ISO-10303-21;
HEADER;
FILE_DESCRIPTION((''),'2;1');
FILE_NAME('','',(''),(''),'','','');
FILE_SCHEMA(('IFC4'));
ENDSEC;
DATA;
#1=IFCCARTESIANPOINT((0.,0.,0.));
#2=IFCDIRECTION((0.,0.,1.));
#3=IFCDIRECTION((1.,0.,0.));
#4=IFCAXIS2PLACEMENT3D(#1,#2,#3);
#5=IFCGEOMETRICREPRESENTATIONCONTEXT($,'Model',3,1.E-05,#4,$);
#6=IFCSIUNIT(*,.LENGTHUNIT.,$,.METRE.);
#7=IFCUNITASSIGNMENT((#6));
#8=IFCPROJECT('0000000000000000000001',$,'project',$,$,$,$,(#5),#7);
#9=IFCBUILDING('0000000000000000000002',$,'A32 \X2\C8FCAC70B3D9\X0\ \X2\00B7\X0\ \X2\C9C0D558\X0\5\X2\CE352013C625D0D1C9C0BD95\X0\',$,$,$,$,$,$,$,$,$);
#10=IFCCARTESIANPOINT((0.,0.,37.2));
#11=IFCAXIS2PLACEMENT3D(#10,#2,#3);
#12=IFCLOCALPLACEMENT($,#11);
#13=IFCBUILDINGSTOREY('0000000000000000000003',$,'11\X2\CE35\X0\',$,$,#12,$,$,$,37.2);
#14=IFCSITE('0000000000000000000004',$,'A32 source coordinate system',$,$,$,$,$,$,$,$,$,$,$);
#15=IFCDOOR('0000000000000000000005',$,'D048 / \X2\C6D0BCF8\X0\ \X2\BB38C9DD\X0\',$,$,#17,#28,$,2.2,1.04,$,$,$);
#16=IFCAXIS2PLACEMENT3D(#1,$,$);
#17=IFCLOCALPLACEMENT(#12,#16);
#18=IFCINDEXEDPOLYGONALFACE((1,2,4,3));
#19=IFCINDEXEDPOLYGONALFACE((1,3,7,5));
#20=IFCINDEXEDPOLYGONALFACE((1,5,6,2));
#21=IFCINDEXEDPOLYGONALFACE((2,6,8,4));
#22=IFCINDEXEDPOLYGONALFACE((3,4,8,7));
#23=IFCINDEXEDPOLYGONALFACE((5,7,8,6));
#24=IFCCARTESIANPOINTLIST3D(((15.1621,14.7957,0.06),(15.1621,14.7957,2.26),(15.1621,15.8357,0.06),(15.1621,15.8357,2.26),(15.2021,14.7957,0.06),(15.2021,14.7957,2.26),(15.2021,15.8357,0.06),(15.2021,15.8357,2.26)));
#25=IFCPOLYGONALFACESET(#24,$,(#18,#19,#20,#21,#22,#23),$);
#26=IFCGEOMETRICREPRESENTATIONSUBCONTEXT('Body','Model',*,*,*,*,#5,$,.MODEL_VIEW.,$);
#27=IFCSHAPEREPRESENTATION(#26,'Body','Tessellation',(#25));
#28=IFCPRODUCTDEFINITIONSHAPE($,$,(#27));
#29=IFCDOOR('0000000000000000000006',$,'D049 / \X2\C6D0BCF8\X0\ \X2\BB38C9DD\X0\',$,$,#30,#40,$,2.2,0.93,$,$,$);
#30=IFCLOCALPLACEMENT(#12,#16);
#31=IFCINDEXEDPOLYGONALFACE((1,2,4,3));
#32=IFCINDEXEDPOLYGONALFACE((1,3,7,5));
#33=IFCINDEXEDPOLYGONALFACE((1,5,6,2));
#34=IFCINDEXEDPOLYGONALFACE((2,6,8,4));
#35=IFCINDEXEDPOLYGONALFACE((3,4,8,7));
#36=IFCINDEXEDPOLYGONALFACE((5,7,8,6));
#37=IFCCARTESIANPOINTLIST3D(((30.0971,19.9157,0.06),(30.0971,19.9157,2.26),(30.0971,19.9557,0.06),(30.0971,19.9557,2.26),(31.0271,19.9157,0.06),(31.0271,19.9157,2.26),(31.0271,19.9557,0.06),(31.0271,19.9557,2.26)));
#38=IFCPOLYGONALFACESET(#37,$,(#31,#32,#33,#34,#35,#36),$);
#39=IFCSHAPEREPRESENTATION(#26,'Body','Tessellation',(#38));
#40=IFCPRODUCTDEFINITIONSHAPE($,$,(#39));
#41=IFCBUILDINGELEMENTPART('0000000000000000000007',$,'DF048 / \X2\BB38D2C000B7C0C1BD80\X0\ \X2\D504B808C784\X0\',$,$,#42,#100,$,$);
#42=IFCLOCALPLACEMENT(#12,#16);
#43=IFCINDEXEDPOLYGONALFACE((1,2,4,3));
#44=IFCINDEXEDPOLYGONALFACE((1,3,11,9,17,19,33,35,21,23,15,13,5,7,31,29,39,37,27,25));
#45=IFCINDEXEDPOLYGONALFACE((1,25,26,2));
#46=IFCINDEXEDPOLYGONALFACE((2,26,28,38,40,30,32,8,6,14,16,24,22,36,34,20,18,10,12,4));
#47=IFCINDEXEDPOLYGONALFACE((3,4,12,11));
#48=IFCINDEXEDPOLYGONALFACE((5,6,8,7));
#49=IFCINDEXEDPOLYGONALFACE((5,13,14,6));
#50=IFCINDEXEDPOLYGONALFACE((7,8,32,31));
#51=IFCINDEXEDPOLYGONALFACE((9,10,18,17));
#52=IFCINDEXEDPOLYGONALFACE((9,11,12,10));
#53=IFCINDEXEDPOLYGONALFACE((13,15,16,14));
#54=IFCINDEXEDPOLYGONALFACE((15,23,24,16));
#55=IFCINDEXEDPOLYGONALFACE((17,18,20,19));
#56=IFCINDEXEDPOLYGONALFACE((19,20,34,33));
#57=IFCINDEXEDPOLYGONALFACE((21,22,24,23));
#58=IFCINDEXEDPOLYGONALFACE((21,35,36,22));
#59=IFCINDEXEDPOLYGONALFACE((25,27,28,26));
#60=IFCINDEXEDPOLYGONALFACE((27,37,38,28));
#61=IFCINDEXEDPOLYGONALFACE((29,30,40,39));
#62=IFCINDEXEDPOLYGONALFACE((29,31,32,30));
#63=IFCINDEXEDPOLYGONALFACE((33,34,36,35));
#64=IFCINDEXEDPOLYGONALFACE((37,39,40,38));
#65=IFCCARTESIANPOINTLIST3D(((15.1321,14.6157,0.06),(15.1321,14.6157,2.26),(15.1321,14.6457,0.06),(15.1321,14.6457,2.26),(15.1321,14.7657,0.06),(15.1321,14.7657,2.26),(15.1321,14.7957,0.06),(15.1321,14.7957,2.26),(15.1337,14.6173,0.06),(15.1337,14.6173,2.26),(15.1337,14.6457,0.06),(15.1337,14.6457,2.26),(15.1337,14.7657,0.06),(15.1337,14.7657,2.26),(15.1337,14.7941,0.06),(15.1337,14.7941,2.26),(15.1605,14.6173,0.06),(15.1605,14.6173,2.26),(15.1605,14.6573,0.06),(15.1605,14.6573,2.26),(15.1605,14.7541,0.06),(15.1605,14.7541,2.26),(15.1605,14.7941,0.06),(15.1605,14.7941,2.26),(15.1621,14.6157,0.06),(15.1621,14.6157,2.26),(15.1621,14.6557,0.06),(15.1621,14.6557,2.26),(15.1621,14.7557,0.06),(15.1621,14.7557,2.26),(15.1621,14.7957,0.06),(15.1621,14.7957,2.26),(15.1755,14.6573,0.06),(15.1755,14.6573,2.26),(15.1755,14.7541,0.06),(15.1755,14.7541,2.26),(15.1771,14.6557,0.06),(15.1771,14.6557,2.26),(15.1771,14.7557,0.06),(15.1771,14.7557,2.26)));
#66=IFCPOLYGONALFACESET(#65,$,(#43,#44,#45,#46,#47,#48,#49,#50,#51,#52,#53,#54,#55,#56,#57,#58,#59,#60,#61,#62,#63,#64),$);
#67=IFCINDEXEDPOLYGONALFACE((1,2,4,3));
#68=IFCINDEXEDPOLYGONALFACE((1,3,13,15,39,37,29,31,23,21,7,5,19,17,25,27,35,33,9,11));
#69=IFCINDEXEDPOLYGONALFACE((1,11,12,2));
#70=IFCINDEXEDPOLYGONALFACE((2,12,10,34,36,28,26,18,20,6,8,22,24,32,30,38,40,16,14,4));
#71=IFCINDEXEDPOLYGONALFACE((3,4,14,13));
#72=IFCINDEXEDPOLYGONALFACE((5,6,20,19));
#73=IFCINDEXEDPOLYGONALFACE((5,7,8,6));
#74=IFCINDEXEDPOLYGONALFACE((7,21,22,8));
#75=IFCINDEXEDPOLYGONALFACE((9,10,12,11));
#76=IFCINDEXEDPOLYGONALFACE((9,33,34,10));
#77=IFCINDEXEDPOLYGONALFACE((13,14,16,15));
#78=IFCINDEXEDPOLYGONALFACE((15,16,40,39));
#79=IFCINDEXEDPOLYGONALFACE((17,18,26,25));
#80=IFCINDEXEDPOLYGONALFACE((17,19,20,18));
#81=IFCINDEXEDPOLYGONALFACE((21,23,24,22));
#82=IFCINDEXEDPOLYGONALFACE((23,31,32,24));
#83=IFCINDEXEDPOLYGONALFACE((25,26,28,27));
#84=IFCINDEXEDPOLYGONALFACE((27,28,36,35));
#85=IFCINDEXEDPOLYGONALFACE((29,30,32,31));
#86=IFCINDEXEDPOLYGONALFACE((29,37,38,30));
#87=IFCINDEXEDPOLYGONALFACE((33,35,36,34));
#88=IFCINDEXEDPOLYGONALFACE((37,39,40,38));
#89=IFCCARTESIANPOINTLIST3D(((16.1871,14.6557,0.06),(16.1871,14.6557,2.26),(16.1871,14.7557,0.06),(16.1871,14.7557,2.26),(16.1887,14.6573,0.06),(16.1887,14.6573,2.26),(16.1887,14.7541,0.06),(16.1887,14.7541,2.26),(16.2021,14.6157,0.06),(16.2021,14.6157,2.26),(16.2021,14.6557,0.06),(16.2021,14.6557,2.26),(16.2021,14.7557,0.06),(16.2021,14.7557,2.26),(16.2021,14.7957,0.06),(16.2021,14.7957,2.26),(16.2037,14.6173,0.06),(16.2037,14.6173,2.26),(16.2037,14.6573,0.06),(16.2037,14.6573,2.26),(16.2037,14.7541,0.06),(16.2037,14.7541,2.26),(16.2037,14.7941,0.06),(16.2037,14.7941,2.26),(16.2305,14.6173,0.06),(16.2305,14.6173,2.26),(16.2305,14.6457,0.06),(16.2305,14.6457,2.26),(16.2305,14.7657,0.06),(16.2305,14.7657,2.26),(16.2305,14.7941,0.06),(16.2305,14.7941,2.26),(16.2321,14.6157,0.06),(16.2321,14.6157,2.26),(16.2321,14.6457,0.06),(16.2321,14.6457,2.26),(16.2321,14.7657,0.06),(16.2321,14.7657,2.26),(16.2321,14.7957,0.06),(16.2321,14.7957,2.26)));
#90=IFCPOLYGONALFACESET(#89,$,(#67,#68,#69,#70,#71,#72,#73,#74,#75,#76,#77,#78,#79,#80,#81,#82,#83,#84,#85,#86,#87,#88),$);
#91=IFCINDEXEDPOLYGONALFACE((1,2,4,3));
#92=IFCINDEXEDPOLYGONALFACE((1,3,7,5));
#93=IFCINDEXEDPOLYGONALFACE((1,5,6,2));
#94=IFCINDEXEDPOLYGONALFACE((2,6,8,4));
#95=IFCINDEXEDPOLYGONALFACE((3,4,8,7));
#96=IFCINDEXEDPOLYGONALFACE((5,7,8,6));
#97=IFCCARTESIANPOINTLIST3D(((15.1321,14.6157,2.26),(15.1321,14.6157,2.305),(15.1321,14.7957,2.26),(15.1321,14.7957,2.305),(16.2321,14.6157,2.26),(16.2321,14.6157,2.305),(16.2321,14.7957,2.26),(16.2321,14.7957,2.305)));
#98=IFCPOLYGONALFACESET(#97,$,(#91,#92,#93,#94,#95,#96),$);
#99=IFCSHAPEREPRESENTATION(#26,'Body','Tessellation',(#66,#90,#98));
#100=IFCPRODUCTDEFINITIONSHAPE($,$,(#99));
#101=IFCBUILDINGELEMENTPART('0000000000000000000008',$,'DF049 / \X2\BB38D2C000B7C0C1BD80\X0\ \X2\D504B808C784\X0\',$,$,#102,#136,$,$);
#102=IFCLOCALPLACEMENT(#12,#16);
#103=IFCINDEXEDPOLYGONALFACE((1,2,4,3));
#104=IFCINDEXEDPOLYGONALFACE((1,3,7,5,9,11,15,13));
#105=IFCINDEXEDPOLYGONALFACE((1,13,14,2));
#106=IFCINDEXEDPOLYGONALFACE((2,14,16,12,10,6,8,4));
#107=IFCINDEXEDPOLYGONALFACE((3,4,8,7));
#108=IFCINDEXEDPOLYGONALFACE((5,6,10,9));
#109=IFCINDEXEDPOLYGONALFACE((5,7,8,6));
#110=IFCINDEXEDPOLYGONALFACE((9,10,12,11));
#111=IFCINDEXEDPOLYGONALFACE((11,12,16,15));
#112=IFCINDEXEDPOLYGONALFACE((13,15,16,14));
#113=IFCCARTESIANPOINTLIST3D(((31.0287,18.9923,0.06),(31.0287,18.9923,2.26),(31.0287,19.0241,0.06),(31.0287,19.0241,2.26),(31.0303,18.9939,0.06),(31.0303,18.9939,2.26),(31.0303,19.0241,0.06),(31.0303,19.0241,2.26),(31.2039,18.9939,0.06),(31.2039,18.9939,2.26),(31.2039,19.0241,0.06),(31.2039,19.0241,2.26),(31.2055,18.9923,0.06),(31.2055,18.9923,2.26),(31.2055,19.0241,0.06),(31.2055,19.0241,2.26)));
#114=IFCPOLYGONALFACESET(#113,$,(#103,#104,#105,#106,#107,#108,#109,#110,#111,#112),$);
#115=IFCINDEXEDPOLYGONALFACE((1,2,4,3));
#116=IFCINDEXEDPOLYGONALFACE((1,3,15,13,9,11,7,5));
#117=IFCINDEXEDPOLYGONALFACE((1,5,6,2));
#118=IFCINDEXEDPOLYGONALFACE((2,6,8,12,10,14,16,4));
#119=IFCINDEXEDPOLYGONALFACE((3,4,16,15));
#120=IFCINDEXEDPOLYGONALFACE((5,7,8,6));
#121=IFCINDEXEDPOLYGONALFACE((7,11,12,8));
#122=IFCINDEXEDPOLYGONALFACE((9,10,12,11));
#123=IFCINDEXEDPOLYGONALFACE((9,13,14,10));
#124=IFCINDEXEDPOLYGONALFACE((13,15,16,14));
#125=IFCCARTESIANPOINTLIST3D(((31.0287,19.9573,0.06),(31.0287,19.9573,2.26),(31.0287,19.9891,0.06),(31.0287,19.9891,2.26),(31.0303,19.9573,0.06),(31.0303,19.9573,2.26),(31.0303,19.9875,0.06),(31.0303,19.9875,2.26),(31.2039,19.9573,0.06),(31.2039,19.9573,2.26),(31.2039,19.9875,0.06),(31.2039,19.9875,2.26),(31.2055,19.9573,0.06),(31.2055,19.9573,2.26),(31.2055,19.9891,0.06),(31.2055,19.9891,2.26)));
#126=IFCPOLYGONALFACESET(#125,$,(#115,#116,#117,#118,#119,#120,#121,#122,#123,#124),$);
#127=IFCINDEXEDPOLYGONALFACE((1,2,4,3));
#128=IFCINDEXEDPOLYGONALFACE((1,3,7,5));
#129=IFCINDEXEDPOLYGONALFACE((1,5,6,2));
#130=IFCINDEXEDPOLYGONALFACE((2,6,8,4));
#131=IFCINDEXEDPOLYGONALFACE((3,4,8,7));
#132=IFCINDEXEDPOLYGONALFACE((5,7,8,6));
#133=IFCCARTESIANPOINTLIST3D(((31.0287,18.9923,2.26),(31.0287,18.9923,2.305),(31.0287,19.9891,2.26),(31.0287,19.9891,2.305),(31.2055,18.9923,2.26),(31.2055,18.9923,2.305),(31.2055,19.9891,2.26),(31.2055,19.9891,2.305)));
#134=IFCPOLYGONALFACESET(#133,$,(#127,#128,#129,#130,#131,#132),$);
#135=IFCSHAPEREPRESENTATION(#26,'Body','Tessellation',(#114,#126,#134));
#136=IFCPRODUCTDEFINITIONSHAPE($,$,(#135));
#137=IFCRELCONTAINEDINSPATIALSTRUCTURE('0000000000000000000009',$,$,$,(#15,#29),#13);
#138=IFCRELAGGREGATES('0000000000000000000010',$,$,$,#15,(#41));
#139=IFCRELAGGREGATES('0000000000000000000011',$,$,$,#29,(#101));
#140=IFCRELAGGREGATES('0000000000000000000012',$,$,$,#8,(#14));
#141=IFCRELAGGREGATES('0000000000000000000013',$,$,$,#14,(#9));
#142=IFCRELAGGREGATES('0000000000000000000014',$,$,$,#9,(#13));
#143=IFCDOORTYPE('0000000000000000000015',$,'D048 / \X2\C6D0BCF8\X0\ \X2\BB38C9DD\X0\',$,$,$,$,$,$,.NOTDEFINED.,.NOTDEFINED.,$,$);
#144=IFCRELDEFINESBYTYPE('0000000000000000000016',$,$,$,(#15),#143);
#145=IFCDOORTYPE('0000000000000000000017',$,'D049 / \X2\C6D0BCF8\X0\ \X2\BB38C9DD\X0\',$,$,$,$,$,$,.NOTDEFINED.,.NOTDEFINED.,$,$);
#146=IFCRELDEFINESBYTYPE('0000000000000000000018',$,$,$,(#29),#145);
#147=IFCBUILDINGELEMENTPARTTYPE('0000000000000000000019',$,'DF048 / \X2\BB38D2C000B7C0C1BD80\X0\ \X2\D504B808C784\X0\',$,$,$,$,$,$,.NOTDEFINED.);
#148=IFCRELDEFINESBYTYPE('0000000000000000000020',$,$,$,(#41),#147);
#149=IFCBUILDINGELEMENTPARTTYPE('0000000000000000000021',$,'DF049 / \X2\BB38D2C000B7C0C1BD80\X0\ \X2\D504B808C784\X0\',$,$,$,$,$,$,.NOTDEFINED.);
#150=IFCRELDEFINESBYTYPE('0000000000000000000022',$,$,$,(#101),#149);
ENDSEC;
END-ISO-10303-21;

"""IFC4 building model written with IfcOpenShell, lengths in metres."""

from ifc_helpers import new_model, si_unit, frame, origin, origin_with_axes, place, context, subcontext, project, spatial, polyline, outline, extrude, source, transform, mapped, type_object, type_shapes, element, aggregate, save


model = new_model("IFC4")

# Units and contexts
model_context = context("Model", 3, precision=1e-05, world=origin_with_axes())
body_context = subcontext(model_context, "Body", "Model", "MODEL_VIEW")
ifc_project = project(units=[si_unit("LENGTHUNIT", "METRE")], contexts=[model_context])

# Site, building, storey
storey_placement = place(None, frame((0.0, 0.0, 37.2), z_axis=(0.0, 0.0, 1.0), x_axis=(1.0, 0.0, 0.0)))
site = spatial("IfcSite", under=ifc_project, Name="A32 source coordinate system")
building = spatial("IfcBuilding", under=site, Name="A32 주거동 · 지하5층–옥탑지붕")
storey = spatial("IfcBuildingStorey", under=building, at=storey_placement, Name="11층", Elevation=37.2)

# Doors
door_type_1 = type_object("IfcDoorType", Name="D048 / 원본 문짝", OperationType="NOTDEFINED", PredefinedType="NOTDEFINED")
shared_shape_1 = source(origin(), body_context, "Body", "SweptSolid", [
    extrude(outline(polyline([(15.2021, 15.8357), (15.2021, 14.7957), (15.1621, 14.7957), (15.1621, 15.8357), (15.2021, 15.8357)])), frame((0.0, 0.0, 0.06)), (0.0, 0.0, 1.0), 2.2),
])
type_shapes(door_type_1, [shared_shape_1])
door_1_placement = place(storey_placement, origin_with_axes())
door_1 = element("IfcDoor", 1, at=door_1_placement, inside=storey, type_object=door_type_1, Name="D048 / 원본 문짝", OverallHeight=2.2, OverallWidth=1.04, context=body_context, shape_type="MappedRepresentation", body=[
    mapped(shared_shape_1, transform((0.0, 0.0, 0.0), scale=1.0)),
])
door_type_2 = type_object("IfcDoorType", Name="D049 / 원본 문짝", OperationType="NOTDEFINED", PredefinedType="NOTDEFINED")
shared_shape_2 = source(origin(), body_context, "Body", "SweptSolid", [
    extrude(outline(polyline([(31.0271, 19.9557), (31.0271, 19.9157), (30.0971, 19.9157), (30.0971, 19.9557), (31.0271, 19.9557)])), frame((0.0, 0.0, 0.06)), (0.0, 0.0, 1.0), 2.2),
])
type_shapes(door_type_2, [shared_shape_2])
door_2_placement = place(storey_placement, origin_with_axes())
door_2 = element("IfcDoor", 2, at=door_2_placement, inside=storey, type_object=door_type_2, Name="D049 / 원본 문짝", OverallHeight=2.2, OverallWidth=0.93, context=body_context, shape_type="MappedRepresentation", body=[
    mapped(shared_shape_2, transform((0.0, 0.0, 0.0), scale=1.0)),
])

# Building element parts
building_element_part_type_1 = type_object("IfcBuildingElementPartType", Name="DF048 / 문틀·상부 프레임", PredefinedType="NOTDEFINED")
shared_shape_3 = source(origin(), body_context, "Body", "SweptSolid", [
    extrude(outline(polyline([(15.1321, 14.7657), (15.1321, 14.7957), (15.1621, 14.7957), (15.1621, 14.7557), (15.1771, 14.7557), (15.1771, 14.6557), (15.1621, 14.6557), (15.1621, 14.6157), (15.1321, 14.6157), (15.1321, 14.6457), (15.1337, 14.6457), (15.1337, 14.6173), (15.1605, 14.6173), (15.1605, 14.6573), (15.1755, 14.6573), (15.1755, 14.7541), (15.1605, 14.7541), (15.1605, 14.7941), (15.1337, 14.7941), (15.1337, 14.7657), (15.1321, 14.7657)])), frame((0.0, 0.0, 0.06)), (0.0, 0.0, 1.0), 2.2),
    extrude(outline(polyline([(16.2305, 14.7941), (16.2037, 14.7941), (16.2037, 14.7541), (16.1887, 14.7541), (16.1887, 14.6573), (16.2037, 14.6573), (16.2037, 14.6173), (16.2305, 14.6173), (16.2305, 14.6457), (16.2321, 14.6457), (16.2321, 14.6157), (16.2021, 14.6157), (16.2021, 14.6557), (16.1871, 14.6557), (16.1871, 14.7557), (16.2021, 14.7557), (16.2021, 14.7957), (16.2321, 14.7957), (16.2321, 14.7657), (16.2305, 14.7657), (16.2305, 14.7941)])), frame((0.0, 0.0, 0.06)), (0.0, 0.0, 1.0), 2.2),
    extrude(outline(polyline([(15.1321, 14.6157), (15.1321, 14.7957), (16.2321, 14.7957), (16.2321, 14.6157), (15.1321, 14.6157)])), frame((0.0, 0.0, 2.26)), (0.0, 0.0, 1.0), 0.045),
])
type_shapes(building_element_part_type_1, [shared_shape_3])
building_element_part_1_placement = place(door_1_placement, origin_with_axes())
building_element_part_1 = element("IfcBuildingElementPart", 3, at=building_element_part_1_placement, type_object=building_element_part_type_1, Name="DF048 / 문틀·상부 프레임", context=body_context, shape_type="MappedRepresentation", body=[
    mapped(shared_shape_3, transform((0.0, 0.0, 0.0), scale=1.0)),
])
aggregate(door_1, [building_element_part_1])
building_element_part_type_2 = type_object("IfcBuildingElementPartType", Name="DF049 / 문틀·상부 프레임", PredefinedType="NOTDEFINED")
shared_shape_4 = source(origin(), body_context, "Body", "SweptSolid", [
    extrude(outline(polyline([(31.0303, 19.0241), (31.0303, 18.9939), (31.2039, 18.9939), (31.2039, 19.0241), (31.2055, 19.0241), (31.2055, 18.9923), (31.0287, 18.9923), (31.0287, 19.0241), (31.0303, 19.0241)])), frame((0.0, 0.0, 0.06)), (0.0, 0.0, 1.0), 2.2),
    extrude(outline(polyline([(31.0287, 19.9891), (31.2055, 19.9891), (31.2055, 19.9573), (31.2039, 19.9573), (31.2039, 19.9875), (31.0303, 19.9875), (31.0303, 19.9573), (31.0287, 19.9573), (31.0287, 19.9891)])), frame((0.0, 0.0, 0.06)), (0.0, 0.0, 1.0), 2.2),
    extrude(outline(polyline([(31.0287, 18.9923), (31.0287, 19.9891), (31.2055, 19.9891), (31.2055, 18.9923), (31.0287, 18.9923)])), frame((0.0, 0.0, 2.26)), (0.0, 0.0, 1.0), 0.045),
])
type_shapes(building_element_part_type_2, [shared_shape_4])
building_element_part_2_placement = place(door_2_placement, origin_with_axes())
building_element_part_2 = element("IfcBuildingElementPart", 4, at=building_element_part_2_placement, type_object=building_element_part_type_2, Name="DF049 / 문틀·상부 프레임", context=body_context, shape_type="MappedRepresentation", body=[
    mapped(shared_shape_4, transform((0.0, 0.0, 0.0), scale=1.0)),
])
aggregate(door_2, [building_element_part_2])

save(model, "model.ifc")
